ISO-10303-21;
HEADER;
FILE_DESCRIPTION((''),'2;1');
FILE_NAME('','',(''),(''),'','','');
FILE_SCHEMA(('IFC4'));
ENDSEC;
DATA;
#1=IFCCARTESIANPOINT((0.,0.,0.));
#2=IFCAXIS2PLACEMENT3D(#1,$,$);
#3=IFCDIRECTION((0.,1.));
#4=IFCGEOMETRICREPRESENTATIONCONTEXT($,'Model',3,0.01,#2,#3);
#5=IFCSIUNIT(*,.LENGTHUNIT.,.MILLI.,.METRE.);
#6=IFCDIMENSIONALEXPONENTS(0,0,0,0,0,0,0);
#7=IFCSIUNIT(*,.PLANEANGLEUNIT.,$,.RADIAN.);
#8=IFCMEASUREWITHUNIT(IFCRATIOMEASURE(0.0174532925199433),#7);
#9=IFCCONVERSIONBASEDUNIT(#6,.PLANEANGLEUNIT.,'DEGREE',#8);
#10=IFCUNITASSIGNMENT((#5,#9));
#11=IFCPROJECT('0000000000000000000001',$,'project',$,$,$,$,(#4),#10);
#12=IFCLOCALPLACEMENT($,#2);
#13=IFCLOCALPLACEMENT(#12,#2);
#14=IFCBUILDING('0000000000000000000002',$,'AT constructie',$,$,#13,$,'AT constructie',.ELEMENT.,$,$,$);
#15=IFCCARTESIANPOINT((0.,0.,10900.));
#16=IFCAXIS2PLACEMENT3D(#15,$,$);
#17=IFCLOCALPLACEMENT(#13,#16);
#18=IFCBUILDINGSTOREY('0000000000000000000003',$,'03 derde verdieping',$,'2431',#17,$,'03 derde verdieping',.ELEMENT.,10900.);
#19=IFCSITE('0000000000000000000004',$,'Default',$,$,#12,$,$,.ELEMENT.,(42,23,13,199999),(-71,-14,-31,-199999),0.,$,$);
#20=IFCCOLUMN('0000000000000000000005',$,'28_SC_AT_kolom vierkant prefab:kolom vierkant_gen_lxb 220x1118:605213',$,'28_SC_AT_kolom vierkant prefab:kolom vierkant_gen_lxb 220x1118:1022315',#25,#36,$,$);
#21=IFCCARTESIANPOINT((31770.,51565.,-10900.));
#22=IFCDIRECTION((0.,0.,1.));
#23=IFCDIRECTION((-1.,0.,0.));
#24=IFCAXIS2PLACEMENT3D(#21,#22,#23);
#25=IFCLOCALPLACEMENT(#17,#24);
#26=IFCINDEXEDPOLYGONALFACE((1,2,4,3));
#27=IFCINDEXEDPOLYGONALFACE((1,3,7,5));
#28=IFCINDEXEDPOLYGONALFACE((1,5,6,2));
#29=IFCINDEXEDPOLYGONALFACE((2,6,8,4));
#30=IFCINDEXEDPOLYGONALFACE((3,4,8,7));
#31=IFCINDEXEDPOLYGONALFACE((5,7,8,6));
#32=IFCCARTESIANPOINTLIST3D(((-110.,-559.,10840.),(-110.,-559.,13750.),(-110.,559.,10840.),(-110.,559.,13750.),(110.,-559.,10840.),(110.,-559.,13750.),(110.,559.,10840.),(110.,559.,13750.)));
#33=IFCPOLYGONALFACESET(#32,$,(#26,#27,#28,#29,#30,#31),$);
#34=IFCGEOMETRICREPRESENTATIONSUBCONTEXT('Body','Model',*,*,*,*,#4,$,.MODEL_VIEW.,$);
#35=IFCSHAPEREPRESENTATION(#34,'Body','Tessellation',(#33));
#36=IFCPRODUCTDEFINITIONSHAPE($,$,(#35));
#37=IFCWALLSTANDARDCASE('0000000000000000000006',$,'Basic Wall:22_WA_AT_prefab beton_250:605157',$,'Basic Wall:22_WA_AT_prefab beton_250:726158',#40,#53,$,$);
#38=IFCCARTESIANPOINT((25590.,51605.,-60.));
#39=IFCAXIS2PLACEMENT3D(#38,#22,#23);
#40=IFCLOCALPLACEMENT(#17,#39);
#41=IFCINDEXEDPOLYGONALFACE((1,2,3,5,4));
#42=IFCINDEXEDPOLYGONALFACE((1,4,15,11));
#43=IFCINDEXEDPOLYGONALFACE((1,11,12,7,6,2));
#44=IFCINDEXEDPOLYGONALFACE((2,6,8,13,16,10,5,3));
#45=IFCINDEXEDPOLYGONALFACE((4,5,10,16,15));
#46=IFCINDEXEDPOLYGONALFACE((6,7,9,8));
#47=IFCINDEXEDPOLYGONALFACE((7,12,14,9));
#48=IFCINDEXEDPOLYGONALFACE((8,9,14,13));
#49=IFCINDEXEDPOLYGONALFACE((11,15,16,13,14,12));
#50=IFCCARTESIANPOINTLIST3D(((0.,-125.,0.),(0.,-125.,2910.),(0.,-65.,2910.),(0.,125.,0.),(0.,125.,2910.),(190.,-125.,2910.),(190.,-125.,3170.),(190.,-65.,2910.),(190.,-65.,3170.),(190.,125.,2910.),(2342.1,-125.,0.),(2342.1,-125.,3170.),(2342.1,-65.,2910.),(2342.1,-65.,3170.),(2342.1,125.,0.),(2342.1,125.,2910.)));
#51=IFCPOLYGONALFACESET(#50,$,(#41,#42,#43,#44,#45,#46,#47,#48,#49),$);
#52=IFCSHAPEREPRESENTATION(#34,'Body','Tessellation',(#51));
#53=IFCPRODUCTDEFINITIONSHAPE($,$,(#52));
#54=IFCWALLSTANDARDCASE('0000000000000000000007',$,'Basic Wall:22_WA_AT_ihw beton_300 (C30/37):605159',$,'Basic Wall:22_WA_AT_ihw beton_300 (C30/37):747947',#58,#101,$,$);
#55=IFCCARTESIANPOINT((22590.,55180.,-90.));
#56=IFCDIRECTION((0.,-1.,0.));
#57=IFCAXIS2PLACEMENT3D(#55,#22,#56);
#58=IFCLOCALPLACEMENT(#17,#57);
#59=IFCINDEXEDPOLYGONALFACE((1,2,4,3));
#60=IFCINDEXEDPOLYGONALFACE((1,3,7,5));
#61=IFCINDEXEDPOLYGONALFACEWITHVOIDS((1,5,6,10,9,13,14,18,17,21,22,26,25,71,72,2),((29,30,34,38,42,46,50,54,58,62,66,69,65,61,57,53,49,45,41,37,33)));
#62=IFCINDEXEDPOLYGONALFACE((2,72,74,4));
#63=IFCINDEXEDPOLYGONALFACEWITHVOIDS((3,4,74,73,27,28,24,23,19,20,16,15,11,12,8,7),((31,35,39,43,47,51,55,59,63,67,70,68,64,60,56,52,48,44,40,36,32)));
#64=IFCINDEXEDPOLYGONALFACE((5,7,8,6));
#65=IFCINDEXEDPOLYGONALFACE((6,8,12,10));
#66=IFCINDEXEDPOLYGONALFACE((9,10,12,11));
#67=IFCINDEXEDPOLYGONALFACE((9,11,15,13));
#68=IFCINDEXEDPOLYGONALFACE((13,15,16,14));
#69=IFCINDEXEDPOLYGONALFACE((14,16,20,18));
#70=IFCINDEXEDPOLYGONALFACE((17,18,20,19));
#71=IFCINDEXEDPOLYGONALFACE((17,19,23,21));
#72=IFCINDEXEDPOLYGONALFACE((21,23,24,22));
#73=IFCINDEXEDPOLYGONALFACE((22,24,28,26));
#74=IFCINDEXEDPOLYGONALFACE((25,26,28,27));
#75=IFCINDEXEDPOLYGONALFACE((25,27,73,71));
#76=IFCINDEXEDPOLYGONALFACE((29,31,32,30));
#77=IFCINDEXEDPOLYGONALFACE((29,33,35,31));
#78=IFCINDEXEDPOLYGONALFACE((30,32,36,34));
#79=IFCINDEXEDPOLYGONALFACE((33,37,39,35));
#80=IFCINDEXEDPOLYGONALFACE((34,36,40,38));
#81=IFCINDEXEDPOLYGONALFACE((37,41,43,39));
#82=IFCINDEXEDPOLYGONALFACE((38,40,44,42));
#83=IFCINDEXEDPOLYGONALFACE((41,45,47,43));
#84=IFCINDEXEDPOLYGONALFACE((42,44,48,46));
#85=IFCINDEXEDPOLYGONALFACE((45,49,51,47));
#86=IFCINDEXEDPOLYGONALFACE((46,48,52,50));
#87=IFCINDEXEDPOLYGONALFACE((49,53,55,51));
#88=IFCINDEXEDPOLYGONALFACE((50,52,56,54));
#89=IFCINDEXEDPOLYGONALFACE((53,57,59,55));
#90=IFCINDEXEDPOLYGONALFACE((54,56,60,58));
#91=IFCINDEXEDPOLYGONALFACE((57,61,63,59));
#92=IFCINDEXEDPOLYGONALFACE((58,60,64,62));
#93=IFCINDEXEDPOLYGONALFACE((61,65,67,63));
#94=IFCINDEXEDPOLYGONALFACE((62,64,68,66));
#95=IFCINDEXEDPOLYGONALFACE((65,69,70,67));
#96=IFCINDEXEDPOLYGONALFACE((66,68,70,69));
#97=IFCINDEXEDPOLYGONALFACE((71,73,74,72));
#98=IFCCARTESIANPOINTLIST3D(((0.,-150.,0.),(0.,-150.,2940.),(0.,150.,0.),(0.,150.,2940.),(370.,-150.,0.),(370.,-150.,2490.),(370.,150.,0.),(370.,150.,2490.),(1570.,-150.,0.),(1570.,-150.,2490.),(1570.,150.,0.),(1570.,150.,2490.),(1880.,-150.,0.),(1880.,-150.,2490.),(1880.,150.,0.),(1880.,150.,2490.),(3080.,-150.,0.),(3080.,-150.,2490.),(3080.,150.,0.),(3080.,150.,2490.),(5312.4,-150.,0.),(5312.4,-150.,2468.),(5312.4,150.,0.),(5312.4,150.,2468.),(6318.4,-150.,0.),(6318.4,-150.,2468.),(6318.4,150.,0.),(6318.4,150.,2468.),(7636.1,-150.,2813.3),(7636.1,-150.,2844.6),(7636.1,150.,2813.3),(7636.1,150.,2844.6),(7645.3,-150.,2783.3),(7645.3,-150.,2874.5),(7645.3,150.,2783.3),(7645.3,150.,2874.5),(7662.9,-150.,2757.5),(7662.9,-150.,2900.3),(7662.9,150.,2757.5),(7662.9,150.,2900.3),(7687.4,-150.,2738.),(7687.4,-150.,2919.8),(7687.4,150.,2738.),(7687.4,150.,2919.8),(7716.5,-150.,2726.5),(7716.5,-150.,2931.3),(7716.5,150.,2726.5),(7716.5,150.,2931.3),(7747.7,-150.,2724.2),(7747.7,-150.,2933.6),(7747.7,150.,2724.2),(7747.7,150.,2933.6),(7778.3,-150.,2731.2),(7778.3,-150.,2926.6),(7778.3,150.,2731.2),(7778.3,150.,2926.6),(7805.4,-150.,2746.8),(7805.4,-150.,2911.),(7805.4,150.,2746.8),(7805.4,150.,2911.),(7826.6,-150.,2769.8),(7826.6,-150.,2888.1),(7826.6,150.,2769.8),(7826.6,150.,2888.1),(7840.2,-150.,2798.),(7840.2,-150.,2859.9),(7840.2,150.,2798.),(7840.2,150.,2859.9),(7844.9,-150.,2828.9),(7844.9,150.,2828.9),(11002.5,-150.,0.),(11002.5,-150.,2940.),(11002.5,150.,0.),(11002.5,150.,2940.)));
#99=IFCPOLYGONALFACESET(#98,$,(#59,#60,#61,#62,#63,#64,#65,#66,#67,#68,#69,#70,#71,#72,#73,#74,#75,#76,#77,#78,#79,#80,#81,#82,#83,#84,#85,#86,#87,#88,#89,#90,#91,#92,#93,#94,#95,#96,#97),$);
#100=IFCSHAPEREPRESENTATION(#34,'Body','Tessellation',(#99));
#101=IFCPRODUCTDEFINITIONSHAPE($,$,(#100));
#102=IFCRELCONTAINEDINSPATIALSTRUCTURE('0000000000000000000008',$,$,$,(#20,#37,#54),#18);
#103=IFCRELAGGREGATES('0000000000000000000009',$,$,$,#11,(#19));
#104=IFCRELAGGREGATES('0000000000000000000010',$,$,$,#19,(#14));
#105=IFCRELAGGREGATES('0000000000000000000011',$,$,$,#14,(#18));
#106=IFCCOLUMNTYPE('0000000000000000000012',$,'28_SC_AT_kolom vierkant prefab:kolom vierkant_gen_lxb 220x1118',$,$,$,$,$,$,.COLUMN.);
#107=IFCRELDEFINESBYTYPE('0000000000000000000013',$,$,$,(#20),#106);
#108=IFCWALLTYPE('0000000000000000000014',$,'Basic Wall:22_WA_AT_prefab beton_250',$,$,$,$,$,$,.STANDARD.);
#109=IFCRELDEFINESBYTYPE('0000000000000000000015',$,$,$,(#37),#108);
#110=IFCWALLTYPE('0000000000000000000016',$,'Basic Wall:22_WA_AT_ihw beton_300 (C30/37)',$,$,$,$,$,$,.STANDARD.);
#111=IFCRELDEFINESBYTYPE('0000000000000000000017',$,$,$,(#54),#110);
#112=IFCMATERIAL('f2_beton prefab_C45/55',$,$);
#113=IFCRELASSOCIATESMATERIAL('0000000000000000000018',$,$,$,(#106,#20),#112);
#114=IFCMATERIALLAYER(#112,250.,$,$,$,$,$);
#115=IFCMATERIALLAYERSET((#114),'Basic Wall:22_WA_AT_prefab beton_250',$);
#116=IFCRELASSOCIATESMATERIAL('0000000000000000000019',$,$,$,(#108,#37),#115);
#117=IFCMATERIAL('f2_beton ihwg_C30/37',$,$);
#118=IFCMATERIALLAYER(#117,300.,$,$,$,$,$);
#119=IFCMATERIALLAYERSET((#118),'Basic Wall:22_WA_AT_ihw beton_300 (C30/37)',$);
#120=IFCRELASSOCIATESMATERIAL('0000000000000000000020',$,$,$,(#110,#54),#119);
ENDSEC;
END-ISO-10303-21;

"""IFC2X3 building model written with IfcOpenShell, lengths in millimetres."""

from ifc_helpers import new_model, entity, si_unit, converted_unit, direction, frame, frame_2d, origin, origin_2d_with_axis, place, context, subcontext, project, spatial, rectangle, circle, extrude, source, transform, mapped, material, layer, layer_set, layer_usage, type_object, type_shapes, element, save


model = new_model("IFC2X3")

# Units and contexts
model_context = context("Model", 3, precision=0.01, world=origin(), true_north=direction((0.0, 1.0)))
body_context = subcontext(model_context, "Body", "Model", "MODEL_VIEW")
ifc_project = project(units=[si_unit("LENGTHUNIT", "METRE", prefix="MILLI"), converted_unit("PLANEANGLEUNIT", "DEGREE", entity("IfcRatioMeasure", 0.0174532925199433), si_unit("PLANEANGLEUNIT", "RADIAN"), dimensions=[0, 0, 0, 0, 0, 0, 0])], contexts=[model_context])

# Site, building, storey
site_placement = place(None, origin())
site = spatial("IfcSite", under=ifc_project, at=site_placement, Name="Default", CompositionType="ELEMENT", RefLatitude=(42, 23, 13, 199999), RefLongitude=(-71, -14, -31, -199999), RefElevation=0.0)
building_placement = place(site_placement, origin())
building = spatial("IfcBuilding", under=site, at=building_placement, Name="AT constructie", LongName="AT constructie", CompositionType="ELEMENT")
storey_placement = place(building_placement, frame((0.0, 0.0, 10900.0)))
storey = spatial("IfcBuildingStorey", under=building, at=storey_placement, Name="03 derde verdieping", ObjectType="2431", LongName="03 derde verdieping", CompositionType="ELEMENT", Elevation=10900.0)

# Column
ifc_material_1 = material(Name="f2_beton prefab_C45/55")
column_type = type_object("IfcColumnType", Name="28_SC_AT_kolom vierkant prefab:kolom vierkant_gen_lxb 220x1118", PredefinedType="COLUMN", material=ifc_material_1)
shared_shape = source(origin(), body_context, "Body", "SweptSolid", [
    extrude(rectangle(XDim=220.0, YDim=1118.0, at=origin_2d_with_axis()), frame((0.0, 0.0, 10840.0), z_axis=(0.0, 0.0, 1.0), x_axis=(-1.0, 0.0, 0.0)), (0.0, 0.0, 1.0), 2910.0),
])
type_shapes(column_type, [shared_shape])
column_placement = place(storey_placement, frame((31770.0, 51565.0, -10900.0), z_axis=(0.0, 0.0, 1.0), x_axis=(-1.0, 0.0, 0.0)))
element("IfcColumn", 1, at=column_placement, inside=storey, type_object=column_type, material=ifc_material_1, Name="28_SC_AT_kolom vierkant prefab:kolom vierkant_gen_lxb 220x1118:605213", ObjectType="28_SC_AT_kolom vierkant prefab:kolom vierkant_gen_lxb 220x1118:1022315", context=body_context, shape_type="MappedRepresentation", body=[
    mapped(shared_shape, transform((0.0, 0.0, 0.0), scale=1.0)),
])

# Wall, openings
ifc_layer_1 = layer(ifc_material_1, 250.0)
ifc_layer_set_1 = layer_set([ifc_layer_1], Name="Basic Wall:22_WA_AT_prefab beton_250")
wall_type_1 = type_object("IfcWallType", Name="Basic Wall:22_WA_AT_prefab beton_250", PredefinedType="STANDARD", material=ifc_layer_set_1)
ifc_layer_usage_1 = layer_usage(ifc_layer_set_1, "AXIS2", "POSITIVE", -125.0)
wall_1_placement = place(storey_placement, frame((25590.0, 51605.0, -60.0), z_axis=(0.0, 0.0, 1.0), x_axis=(-1.0, 0.0, 0.0)))
wall_1 = element("IfcWallStandardCase", 2, at=wall_1_placement, inside=storey, type_object=wall_type_1, material=ifc_layer_usage_1, Name="Basic Wall:22_WA_AT_prefab beton_250:605157", ObjectType="Basic Wall:22_WA_AT_prefab beton_250:726158", context=body_context, shape_type="SweptSolid", body=[
    extrude(rectangle(XDim=2342.1, YDim=250.0, at=frame_2d((1171.1, 0.0), x_axis=(-1.0, 0.0))), origin(), (0.0, 0.0, 1.0), 3170.0),
])
opening_1_placement = place(wall_1_placement, origin())
element("IfcOpeningElement", 3, at=opening_1_placement, cuts=wall_1, ObjectType="Opening", context=body_context, shape_type="SweptSolid", body=[
    extrude(rectangle(XDim=260.0, YDim=190.0, at=frame_2d((0.0, 0.0), x_axis=(0.0, 1.0))), frame((95.0, -3775.0, 3040.0), z_axis=(0.0, 1.0, 0.0), x_axis=(1.0, 0.0, 0.0)), (0.0, 0.0, 1.0), 3900.0),
])
opening_2_placement = place(wall_1_placement, origin())
element("IfcOpeningElement", 4, at=opening_2_placement, cuts=wall_1, ObjectType="Recess", context=body_context, shape_type="SweptSolid", body=[
    extrude(rectangle(XDim=260.0, YDim=2366.8, at=frame_2d((0.0, 0.0), x_axis=(1.0, 0.0))), frame((1166.6, -65.0, 3040.0), z_axis=(0.0, 1.0, 0.0), x_axis=(0.0, 0.0, -1.0)), (0.0, 0.0, 1.0), 190.0),
])

# Shared definitions
ifc_material_2 = material(Name="f2_beton ihwg_C30/37")

# Wall, openings
ifc_layer_2 = layer(ifc_material_2, 300.0)
ifc_layer_set_2 = layer_set([ifc_layer_2], Name="Basic Wall:22_WA_AT_ihw beton_300 (C30/37)")
ifc_layer_usage_2 = layer_usage(ifc_layer_set_2, "AXIS2", "NEGATIVE", 150.0)
wall_type_2 = type_object("IfcWallType", Name="Basic Wall:22_WA_AT_ihw beton_300 (C30/37)", PredefinedType="STANDARD", material=ifc_layer_set_2)
wall_2_placement = place(storey_placement, frame((22590.0, 55180.0, -90.0), z_axis=(0.0, 0.0, 1.0), x_axis=(0.0, -1.0, 0.0)))
wall_2 = element("IfcWallStandardCase", 5, at=wall_2_placement, inside=storey, type_object=wall_type_2, material=ifc_layer_usage_2, Name="Basic Wall:22_WA_AT_ihw beton_300 (C30/37):605159", ObjectType="Basic Wall:22_WA_AT_ihw beton_300 (C30/37):747947", context=body_context, shape_type="SweptSolid", body=[
    extrude(rectangle(XDim=11002.5, YDim=300.0, at=frame_2d((5501.2, 0.0), x_axis=(-1.0, 0.0))), origin(), (0.0, 0.0, 1.0), 2940.0),
])
opening_3_placement = place(wall_2_placement, origin())
element("IfcOpeningElement", 6, at=opening_3_placement, cuts=wall_2, ObjectType="Opening", context=body_context, shape_type="SweptSolid", body=[
    extrude(rectangle(XDim=2490.0, YDim=1200.0, at=frame_2d((0.0, 0.0), x_axis=(1.0, 0.0))), frame((970.0, -1374.0, 1245.0), z_axis=(0.0, 1.0, 0.0), x_axis=(0.0, 0.0, -1.0)), (0.0, 0.0, 1.0), 3048.0),
])
opening_4_placement = place(wall_2_placement, origin())
element("IfcOpeningElement", 7, at=opening_4_placement, cuts=wall_2, ObjectType="Opening", context=body_context, shape_type="SweptSolid", body=[
    extrude(rectangle(XDim=2490.0, YDim=1200.0, at=frame_2d((0.0, 0.0), x_axis=(1.0, 0.0))), frame((2480.0, -1374.0, 1245.0), z_axis=(0.0, 1.0, 0.0), x_axis=(0.0, 0.0, -1.0)), (0.0, 0.0, 1.0), 3048.0),
])
opening_5_placement = place(wall_2_placement, origin())
element("IfcOpeningElement", 8, at=opening_5_placement, cuts=wall_2, ObjectType="Opening", context=body_context, shape_type="SweptSolid", body=[
    extrude(rectangle(XDim=2468.0, YDim=1006.0, at=frame_2d((0.0, 0.0), x_axis=(1.0, 0.0))), frame((5815.4, -1374.0, 1234.0), z_axis=(0.0, 1.0, 0.0), x_axis=(0.0, 0.0, -1.0)), (0.0, 0.0, 1.0), 3048.0),
])
opening_6_placement = place(wall_2_placement, origin())
element("IfcOpeningElement", 9, at=opening_6_placement, cuts=wall_2, ObjectType="Opening", context=body_context, shape_type="SweptSolid", body=[
    extrude(circle(Radius=105.0, at=origin_2d_with_axis()), frame((7739.9, -150.0, 2828.9), z_axis=(0.0, 1.0, 0.0), x_axis=(1.0, 0.0, 0.0)), (0.0, 0.0, 1.0), 300.0),
])

save(model, "model.ifc")
